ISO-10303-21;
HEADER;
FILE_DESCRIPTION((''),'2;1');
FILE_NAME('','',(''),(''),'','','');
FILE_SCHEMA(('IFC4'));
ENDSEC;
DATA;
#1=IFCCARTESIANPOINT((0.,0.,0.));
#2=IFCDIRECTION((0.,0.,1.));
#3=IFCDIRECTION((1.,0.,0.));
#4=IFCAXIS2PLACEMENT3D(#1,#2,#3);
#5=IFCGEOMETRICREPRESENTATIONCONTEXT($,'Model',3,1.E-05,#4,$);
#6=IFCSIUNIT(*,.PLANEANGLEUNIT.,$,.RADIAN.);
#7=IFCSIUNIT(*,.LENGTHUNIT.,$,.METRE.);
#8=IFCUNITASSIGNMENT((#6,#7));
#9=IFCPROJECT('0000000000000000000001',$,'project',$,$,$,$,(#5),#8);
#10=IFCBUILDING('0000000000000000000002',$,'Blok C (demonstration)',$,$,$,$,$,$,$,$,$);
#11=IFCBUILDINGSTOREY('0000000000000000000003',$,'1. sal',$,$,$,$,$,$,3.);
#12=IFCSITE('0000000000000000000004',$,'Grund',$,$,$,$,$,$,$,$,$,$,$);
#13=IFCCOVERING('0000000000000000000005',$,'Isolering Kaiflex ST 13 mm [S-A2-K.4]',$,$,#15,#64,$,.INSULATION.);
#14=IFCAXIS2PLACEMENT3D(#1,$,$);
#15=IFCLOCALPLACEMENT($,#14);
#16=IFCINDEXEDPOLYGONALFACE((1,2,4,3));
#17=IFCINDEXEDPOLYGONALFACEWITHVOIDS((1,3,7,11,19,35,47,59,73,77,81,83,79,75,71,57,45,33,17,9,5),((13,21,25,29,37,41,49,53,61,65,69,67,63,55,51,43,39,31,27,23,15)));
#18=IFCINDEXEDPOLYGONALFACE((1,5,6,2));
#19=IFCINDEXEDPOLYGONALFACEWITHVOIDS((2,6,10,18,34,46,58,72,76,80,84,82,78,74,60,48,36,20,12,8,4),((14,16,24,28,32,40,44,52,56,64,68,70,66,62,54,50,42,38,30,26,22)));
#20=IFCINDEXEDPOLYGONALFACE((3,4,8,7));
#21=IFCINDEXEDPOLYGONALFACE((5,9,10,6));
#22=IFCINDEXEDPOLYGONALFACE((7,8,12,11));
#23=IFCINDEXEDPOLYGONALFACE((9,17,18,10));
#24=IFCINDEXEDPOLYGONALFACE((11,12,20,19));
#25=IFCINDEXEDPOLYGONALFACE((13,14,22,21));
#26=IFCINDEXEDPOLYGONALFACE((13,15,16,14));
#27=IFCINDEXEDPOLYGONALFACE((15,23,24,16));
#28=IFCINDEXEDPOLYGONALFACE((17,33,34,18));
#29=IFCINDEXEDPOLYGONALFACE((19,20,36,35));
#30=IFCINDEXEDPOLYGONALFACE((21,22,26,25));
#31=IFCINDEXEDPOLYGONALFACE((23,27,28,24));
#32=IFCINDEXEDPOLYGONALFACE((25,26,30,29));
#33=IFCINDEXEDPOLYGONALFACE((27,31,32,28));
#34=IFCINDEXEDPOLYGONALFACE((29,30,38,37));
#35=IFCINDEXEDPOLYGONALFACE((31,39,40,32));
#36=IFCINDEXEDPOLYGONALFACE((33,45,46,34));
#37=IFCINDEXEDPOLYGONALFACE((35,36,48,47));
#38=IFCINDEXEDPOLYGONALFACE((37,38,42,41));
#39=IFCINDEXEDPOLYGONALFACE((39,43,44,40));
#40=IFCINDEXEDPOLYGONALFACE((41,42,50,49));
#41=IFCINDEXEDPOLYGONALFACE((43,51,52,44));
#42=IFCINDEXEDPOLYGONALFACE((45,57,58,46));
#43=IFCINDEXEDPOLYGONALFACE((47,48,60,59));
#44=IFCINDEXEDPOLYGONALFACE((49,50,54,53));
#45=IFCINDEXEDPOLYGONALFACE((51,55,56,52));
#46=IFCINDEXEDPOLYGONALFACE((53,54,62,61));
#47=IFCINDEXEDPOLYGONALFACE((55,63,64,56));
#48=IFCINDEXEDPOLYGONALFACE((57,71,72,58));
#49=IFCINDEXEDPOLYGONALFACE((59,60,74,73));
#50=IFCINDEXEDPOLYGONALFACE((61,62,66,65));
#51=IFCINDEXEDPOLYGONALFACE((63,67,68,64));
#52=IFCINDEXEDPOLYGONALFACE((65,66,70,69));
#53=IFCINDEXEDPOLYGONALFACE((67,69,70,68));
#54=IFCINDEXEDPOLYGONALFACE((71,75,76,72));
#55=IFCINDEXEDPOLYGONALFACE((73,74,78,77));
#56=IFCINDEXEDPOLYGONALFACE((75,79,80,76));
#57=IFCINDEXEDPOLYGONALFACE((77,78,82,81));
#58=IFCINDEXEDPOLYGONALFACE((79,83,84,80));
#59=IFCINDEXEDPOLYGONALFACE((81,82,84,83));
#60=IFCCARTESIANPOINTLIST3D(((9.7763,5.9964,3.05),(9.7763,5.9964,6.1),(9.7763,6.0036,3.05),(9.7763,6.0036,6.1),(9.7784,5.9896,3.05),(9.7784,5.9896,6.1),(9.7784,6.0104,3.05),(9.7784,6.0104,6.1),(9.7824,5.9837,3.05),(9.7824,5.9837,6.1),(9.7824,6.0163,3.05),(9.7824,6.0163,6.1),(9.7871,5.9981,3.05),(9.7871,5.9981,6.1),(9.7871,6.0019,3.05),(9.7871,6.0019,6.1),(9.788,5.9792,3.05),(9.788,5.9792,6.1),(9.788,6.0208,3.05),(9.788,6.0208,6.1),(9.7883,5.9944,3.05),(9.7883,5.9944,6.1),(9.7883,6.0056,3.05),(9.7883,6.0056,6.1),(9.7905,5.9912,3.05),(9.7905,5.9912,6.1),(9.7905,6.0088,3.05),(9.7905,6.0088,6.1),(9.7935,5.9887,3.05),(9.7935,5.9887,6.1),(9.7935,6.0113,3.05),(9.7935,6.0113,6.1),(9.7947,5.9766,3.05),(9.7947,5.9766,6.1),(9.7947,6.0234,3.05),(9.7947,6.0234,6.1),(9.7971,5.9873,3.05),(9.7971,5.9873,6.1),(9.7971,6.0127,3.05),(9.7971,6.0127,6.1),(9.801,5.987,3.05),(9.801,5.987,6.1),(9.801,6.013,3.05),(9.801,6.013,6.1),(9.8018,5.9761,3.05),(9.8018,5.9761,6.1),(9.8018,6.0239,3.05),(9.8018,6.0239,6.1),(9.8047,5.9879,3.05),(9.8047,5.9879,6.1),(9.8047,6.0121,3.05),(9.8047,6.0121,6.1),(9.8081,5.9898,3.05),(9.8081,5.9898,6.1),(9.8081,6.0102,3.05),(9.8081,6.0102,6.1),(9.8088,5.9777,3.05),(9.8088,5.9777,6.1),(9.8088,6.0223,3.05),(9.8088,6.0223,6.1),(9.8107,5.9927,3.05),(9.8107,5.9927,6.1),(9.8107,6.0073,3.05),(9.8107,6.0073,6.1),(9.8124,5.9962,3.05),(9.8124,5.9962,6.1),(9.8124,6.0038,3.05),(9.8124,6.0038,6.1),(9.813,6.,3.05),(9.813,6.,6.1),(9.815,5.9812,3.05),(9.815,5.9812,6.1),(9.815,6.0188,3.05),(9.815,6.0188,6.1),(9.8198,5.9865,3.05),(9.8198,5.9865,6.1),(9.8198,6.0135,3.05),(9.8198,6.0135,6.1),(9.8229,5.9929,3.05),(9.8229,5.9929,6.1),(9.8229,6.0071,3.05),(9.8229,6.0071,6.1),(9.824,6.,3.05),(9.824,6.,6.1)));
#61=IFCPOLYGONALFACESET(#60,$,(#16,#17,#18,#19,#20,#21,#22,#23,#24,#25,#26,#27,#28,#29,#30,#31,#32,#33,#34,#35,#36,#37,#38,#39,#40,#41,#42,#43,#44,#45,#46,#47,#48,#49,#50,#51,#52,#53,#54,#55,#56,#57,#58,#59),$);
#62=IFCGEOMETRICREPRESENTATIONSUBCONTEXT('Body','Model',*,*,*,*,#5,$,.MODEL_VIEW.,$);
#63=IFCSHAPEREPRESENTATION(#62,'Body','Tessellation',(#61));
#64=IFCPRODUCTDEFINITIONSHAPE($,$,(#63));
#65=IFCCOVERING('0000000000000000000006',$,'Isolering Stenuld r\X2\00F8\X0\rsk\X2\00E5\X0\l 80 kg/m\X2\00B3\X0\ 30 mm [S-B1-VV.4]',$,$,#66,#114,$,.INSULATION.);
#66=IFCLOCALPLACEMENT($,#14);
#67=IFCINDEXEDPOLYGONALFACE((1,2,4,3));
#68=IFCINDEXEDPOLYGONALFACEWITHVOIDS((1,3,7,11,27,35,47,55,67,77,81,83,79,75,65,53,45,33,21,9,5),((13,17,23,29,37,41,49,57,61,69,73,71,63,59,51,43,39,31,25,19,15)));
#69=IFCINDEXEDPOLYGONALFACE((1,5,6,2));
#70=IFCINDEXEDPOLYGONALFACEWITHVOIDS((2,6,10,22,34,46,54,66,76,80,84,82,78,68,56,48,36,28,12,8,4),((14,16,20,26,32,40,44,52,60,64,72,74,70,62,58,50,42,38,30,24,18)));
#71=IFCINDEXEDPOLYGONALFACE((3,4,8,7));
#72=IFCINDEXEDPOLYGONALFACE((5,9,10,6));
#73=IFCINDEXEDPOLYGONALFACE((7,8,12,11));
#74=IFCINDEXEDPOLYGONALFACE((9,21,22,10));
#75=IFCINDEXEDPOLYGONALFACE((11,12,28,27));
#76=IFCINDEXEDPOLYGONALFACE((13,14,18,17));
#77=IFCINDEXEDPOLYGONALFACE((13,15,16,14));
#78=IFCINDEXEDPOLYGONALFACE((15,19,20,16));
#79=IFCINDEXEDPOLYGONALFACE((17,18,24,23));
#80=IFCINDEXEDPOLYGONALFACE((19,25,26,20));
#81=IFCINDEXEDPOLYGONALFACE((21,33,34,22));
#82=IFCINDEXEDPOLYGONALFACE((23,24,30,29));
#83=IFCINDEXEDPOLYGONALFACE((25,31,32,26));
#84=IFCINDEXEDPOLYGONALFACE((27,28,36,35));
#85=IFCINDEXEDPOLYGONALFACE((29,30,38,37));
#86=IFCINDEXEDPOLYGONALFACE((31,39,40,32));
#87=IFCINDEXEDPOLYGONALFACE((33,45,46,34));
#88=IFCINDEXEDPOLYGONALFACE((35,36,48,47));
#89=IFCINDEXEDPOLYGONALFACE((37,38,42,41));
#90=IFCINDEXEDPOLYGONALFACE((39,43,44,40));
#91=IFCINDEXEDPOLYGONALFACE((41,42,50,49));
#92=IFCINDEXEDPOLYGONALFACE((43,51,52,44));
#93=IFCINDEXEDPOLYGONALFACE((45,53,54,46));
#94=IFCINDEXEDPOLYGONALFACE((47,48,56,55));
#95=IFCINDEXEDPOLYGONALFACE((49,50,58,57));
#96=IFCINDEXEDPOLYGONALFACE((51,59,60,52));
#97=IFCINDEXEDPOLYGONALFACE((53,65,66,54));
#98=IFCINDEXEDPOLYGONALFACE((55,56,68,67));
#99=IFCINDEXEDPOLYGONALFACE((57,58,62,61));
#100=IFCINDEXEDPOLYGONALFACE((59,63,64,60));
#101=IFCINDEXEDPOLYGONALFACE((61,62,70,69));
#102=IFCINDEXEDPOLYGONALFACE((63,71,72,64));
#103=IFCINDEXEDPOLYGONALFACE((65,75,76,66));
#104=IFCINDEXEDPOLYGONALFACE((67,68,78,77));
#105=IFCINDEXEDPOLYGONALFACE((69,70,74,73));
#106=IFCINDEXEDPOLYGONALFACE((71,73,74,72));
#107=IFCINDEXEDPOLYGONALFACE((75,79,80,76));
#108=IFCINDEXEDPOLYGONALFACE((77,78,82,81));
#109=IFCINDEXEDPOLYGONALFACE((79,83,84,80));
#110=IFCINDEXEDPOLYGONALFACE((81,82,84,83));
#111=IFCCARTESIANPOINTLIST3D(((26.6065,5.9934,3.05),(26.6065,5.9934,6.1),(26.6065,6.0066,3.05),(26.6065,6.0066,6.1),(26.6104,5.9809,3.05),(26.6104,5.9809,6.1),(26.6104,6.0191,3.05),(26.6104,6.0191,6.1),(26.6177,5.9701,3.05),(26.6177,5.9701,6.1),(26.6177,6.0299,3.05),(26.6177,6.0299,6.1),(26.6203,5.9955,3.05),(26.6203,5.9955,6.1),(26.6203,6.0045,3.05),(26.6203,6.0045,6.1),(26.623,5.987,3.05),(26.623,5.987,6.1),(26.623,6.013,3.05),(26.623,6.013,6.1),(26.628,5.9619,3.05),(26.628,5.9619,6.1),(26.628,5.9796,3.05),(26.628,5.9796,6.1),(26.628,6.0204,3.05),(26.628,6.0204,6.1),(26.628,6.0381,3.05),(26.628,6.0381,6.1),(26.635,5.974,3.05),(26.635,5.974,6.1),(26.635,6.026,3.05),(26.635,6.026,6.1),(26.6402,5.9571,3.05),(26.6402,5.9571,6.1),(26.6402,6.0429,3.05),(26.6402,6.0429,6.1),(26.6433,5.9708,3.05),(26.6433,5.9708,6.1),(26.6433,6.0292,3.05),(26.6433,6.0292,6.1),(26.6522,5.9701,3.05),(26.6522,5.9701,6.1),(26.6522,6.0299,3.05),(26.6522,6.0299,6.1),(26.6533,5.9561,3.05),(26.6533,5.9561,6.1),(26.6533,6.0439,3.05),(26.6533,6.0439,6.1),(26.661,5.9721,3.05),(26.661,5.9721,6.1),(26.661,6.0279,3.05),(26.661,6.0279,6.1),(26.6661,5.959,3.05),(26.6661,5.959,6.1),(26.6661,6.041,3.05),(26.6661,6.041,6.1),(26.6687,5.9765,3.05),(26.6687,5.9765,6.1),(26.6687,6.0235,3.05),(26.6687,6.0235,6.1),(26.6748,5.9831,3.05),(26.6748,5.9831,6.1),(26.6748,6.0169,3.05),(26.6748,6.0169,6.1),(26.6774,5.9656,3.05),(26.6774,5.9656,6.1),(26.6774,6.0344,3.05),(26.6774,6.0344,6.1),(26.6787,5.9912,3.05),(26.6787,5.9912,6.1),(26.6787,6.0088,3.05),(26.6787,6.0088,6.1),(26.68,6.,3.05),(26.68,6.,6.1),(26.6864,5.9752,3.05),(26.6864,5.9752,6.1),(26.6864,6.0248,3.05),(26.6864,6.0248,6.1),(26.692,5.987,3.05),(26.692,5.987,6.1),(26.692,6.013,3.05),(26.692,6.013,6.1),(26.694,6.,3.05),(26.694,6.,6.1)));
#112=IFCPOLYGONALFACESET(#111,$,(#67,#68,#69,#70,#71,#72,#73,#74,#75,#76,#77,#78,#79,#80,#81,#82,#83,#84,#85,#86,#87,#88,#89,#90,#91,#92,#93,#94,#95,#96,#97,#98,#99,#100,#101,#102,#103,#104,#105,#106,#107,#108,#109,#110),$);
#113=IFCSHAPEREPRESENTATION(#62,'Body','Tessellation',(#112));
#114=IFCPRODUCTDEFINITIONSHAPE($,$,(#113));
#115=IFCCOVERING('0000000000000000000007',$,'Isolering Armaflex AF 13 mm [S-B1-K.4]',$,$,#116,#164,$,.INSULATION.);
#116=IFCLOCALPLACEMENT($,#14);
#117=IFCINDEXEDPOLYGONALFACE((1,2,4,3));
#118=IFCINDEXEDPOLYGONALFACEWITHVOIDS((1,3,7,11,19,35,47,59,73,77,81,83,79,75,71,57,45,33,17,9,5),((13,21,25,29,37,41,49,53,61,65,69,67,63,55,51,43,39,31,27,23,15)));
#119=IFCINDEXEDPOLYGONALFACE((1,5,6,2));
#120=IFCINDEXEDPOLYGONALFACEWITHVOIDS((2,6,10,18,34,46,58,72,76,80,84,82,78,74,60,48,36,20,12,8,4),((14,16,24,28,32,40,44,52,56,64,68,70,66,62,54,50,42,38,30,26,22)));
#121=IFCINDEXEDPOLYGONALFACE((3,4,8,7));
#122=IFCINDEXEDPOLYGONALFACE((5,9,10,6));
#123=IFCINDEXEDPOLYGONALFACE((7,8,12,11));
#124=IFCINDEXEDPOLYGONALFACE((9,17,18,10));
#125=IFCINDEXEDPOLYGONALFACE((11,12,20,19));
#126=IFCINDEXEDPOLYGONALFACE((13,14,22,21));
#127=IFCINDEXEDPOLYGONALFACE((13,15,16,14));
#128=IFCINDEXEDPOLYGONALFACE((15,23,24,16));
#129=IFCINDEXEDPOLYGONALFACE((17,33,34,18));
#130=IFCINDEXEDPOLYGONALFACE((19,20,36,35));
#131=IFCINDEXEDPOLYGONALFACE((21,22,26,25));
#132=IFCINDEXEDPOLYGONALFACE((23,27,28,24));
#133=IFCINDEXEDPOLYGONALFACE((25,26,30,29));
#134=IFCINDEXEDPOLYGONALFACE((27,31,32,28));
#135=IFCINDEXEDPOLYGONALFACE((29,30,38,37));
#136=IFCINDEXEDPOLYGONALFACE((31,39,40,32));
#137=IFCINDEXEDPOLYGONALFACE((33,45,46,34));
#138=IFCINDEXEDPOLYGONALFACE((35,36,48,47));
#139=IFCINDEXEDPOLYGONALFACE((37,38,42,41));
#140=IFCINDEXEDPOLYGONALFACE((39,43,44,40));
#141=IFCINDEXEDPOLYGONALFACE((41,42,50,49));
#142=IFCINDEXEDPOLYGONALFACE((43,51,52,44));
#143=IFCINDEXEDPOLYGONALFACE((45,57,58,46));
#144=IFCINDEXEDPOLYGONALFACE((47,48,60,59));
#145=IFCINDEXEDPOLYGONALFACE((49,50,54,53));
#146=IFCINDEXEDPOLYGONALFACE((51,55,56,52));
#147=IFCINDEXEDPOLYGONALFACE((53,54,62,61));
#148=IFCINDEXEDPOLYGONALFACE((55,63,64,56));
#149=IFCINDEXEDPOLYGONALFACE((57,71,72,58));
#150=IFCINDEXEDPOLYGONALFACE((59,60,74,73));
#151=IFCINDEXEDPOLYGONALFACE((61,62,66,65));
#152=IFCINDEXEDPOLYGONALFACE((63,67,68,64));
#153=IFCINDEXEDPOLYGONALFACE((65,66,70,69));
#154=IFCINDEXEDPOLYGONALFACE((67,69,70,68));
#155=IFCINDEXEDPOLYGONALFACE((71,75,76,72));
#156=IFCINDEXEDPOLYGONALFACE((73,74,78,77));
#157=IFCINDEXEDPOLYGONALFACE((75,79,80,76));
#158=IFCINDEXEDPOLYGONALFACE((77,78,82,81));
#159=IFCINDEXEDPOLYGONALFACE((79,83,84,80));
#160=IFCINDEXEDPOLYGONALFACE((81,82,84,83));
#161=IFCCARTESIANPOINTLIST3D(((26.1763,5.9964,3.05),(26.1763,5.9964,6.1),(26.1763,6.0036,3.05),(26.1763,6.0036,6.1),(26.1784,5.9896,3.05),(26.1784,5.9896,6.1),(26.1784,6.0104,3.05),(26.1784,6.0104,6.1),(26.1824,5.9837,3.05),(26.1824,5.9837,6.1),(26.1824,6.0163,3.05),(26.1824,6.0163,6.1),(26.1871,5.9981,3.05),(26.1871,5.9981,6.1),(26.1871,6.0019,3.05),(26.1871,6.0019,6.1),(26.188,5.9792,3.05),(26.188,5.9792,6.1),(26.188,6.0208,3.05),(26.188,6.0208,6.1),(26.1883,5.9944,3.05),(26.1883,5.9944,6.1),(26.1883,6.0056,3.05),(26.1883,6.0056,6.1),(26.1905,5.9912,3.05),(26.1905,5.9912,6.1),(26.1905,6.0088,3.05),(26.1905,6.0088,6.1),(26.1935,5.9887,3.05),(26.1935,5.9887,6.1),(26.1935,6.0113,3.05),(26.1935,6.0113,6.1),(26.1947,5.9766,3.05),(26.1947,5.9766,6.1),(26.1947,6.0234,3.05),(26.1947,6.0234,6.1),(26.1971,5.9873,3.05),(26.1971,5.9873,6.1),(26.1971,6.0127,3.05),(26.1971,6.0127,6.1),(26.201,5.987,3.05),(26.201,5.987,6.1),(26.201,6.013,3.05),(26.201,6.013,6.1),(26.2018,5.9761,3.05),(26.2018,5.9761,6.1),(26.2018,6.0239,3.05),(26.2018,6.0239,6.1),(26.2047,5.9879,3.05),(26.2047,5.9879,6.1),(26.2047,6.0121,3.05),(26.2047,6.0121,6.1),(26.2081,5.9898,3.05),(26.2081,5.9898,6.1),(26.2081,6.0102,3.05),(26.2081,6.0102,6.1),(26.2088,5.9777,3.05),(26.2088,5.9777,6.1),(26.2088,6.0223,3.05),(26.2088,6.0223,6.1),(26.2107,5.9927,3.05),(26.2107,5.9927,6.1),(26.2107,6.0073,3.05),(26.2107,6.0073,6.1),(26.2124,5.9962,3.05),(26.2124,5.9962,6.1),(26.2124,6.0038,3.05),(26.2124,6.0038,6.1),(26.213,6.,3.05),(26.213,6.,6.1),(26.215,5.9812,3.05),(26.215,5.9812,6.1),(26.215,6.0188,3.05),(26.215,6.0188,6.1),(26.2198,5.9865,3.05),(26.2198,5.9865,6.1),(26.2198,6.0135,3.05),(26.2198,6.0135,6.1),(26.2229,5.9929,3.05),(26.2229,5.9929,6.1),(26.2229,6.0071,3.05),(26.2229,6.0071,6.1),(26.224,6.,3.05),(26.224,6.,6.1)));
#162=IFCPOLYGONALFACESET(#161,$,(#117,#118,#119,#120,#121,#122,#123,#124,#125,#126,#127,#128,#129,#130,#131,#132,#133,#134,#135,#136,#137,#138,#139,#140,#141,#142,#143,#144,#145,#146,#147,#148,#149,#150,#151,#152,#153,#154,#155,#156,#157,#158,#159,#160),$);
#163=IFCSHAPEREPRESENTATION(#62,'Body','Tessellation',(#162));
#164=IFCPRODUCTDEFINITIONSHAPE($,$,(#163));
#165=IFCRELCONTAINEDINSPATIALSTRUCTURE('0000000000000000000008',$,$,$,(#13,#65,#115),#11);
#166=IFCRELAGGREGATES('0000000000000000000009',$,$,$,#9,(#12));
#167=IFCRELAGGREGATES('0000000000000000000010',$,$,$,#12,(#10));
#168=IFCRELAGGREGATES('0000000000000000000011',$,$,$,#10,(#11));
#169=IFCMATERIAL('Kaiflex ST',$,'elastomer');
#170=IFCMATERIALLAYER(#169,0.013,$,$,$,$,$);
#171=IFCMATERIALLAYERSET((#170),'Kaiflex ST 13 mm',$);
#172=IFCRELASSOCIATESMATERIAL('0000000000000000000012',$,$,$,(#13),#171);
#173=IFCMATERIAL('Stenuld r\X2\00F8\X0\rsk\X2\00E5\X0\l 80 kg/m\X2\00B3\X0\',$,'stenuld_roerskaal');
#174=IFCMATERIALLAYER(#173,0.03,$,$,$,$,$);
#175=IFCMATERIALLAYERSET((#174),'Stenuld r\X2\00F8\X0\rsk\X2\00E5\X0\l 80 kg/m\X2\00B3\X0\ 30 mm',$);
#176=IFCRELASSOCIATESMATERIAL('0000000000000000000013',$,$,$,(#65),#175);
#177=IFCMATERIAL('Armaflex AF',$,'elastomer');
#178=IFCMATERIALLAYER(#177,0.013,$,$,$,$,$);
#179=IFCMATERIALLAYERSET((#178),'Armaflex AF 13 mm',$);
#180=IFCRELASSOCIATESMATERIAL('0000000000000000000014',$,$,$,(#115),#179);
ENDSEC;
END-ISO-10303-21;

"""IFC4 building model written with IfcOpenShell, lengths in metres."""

from ifc_helpers import new_model, si_unit, frame, origin_with_axes, place, context, subcontext, project, spatial, hollow_circle, extrude, material, layer, layer_set, element, save


model = new_model("IFC4")

# Units and contexts
model_context = context("Model", 3, precision=1e-05, world=origin_with_axes())
body_context = subcontext(model_context, "Body", "Model", "MODEL_VIEW")
ifc_project = project(units=[si_unit("PLANEANGLEUNIT", "RADIAN"), si_unit("LENGTHUNIT", "METRE")], contexts=[model_context])

# Site, building, storey
site = spatial("IfcSite", under=ifc_project, Name="Grund")
building = spatial("IfcBuilding", under=site, Name="Blok C (demonstration)")
storey = spatial("IfcBuildingStorey", under=building, Name="1. sal", Elevation=3.0)

# Coverings
ifc_material_1 = material(Name="Stenuld rørskål 80 kg/m³", Category="stenuld_roerskaal")
ifc_material_2 = material(Name="Kaiflex ST", Category="elastomer")
ifc_layer_1 = layer(ifc_material_2, 0.013)
ifc_layer_set_1 = layer_set([ifc_layer_1], Name="Kaiflex ST 13 mm")
covering_1_placement = place(None, origin_with_axes())
element("IfcCovering", 1, at=covering_1_placement, inside=storey, material=ifc_layer_set_1, Name="Isolering Kaiflex ST 13 mm [S-A2-K.4]", PredefinedType="INSULATION", context=body_context, shape_type="SweptSolid", body=[
    extrude(hollow_circle(Radius=0.024, WallThickness=0.011), frame((9.8, 6.0, 3.05), z_axis=(0.0, 0.0, 1.0), x_axis=(1.0, 0.0, 0.0)), (0.0, 0.0, 1.0), 3.05),
])
ifc_layer_2 = layer(ifc_material_1, 0.03)
ifc_layer_set_2 = layer_set([ifc_layer_2], Name="Stenuld rørskål 80 kg/m³ 30 mm")
covering_2_placement = place(None, origin_with_axes())
element("IfcCovering", 2, at=covering_2_placement, inside=storey, material=ifc_layer_set_2, Name="Isolering Stenuld rørskål 80 kg/m³ 30 mm [S-B1-VV.4]", PredefinedType="INSULATION", context=body_context, shape_type="SweptSolid", body=[
    extrude(hollow_circle(Radius=0.044, WallThickness=0.014), frame((26.65, 6.0, 3.05), z_axis=(0.0, 0.0, 1.0), x_axis=(1.0, 0.0, 0.0)), (0.0, 0.0, 1.0), 3.05),
])
ifc_material_3 = material(Name="Armaflex AF", Category="elastomer")
ifc_layer_3 = layer(ifc_material_3, 0.013)
ifc_layer_set_3 = layer_set([ifc_layer_3], Name="Armaflex AF 13 mm")
covering_3_placement = place(None, origin_with_axes())
element("IfcCovering", 3, at=covering_3_placement, inside=storey, material=ifc_layer_set_3, Name="Isolering Armaflex AF 13 mm [S-B1-K.4]", PredefinedType="INSULATION", context=body_context, shape_type="SweptSolid", body=[
    extrude(hollow_circle(Radius=0.024, WallThickness=0.011), frame((26.2, 6.0, 3.05), z_axis=(0.0, 0.0, 1.0), x_axis=(1.0, 0.0, 0.0)), (0.0, 0.0, 1.0), 3.05),
])

save(model, "model.ifc")
